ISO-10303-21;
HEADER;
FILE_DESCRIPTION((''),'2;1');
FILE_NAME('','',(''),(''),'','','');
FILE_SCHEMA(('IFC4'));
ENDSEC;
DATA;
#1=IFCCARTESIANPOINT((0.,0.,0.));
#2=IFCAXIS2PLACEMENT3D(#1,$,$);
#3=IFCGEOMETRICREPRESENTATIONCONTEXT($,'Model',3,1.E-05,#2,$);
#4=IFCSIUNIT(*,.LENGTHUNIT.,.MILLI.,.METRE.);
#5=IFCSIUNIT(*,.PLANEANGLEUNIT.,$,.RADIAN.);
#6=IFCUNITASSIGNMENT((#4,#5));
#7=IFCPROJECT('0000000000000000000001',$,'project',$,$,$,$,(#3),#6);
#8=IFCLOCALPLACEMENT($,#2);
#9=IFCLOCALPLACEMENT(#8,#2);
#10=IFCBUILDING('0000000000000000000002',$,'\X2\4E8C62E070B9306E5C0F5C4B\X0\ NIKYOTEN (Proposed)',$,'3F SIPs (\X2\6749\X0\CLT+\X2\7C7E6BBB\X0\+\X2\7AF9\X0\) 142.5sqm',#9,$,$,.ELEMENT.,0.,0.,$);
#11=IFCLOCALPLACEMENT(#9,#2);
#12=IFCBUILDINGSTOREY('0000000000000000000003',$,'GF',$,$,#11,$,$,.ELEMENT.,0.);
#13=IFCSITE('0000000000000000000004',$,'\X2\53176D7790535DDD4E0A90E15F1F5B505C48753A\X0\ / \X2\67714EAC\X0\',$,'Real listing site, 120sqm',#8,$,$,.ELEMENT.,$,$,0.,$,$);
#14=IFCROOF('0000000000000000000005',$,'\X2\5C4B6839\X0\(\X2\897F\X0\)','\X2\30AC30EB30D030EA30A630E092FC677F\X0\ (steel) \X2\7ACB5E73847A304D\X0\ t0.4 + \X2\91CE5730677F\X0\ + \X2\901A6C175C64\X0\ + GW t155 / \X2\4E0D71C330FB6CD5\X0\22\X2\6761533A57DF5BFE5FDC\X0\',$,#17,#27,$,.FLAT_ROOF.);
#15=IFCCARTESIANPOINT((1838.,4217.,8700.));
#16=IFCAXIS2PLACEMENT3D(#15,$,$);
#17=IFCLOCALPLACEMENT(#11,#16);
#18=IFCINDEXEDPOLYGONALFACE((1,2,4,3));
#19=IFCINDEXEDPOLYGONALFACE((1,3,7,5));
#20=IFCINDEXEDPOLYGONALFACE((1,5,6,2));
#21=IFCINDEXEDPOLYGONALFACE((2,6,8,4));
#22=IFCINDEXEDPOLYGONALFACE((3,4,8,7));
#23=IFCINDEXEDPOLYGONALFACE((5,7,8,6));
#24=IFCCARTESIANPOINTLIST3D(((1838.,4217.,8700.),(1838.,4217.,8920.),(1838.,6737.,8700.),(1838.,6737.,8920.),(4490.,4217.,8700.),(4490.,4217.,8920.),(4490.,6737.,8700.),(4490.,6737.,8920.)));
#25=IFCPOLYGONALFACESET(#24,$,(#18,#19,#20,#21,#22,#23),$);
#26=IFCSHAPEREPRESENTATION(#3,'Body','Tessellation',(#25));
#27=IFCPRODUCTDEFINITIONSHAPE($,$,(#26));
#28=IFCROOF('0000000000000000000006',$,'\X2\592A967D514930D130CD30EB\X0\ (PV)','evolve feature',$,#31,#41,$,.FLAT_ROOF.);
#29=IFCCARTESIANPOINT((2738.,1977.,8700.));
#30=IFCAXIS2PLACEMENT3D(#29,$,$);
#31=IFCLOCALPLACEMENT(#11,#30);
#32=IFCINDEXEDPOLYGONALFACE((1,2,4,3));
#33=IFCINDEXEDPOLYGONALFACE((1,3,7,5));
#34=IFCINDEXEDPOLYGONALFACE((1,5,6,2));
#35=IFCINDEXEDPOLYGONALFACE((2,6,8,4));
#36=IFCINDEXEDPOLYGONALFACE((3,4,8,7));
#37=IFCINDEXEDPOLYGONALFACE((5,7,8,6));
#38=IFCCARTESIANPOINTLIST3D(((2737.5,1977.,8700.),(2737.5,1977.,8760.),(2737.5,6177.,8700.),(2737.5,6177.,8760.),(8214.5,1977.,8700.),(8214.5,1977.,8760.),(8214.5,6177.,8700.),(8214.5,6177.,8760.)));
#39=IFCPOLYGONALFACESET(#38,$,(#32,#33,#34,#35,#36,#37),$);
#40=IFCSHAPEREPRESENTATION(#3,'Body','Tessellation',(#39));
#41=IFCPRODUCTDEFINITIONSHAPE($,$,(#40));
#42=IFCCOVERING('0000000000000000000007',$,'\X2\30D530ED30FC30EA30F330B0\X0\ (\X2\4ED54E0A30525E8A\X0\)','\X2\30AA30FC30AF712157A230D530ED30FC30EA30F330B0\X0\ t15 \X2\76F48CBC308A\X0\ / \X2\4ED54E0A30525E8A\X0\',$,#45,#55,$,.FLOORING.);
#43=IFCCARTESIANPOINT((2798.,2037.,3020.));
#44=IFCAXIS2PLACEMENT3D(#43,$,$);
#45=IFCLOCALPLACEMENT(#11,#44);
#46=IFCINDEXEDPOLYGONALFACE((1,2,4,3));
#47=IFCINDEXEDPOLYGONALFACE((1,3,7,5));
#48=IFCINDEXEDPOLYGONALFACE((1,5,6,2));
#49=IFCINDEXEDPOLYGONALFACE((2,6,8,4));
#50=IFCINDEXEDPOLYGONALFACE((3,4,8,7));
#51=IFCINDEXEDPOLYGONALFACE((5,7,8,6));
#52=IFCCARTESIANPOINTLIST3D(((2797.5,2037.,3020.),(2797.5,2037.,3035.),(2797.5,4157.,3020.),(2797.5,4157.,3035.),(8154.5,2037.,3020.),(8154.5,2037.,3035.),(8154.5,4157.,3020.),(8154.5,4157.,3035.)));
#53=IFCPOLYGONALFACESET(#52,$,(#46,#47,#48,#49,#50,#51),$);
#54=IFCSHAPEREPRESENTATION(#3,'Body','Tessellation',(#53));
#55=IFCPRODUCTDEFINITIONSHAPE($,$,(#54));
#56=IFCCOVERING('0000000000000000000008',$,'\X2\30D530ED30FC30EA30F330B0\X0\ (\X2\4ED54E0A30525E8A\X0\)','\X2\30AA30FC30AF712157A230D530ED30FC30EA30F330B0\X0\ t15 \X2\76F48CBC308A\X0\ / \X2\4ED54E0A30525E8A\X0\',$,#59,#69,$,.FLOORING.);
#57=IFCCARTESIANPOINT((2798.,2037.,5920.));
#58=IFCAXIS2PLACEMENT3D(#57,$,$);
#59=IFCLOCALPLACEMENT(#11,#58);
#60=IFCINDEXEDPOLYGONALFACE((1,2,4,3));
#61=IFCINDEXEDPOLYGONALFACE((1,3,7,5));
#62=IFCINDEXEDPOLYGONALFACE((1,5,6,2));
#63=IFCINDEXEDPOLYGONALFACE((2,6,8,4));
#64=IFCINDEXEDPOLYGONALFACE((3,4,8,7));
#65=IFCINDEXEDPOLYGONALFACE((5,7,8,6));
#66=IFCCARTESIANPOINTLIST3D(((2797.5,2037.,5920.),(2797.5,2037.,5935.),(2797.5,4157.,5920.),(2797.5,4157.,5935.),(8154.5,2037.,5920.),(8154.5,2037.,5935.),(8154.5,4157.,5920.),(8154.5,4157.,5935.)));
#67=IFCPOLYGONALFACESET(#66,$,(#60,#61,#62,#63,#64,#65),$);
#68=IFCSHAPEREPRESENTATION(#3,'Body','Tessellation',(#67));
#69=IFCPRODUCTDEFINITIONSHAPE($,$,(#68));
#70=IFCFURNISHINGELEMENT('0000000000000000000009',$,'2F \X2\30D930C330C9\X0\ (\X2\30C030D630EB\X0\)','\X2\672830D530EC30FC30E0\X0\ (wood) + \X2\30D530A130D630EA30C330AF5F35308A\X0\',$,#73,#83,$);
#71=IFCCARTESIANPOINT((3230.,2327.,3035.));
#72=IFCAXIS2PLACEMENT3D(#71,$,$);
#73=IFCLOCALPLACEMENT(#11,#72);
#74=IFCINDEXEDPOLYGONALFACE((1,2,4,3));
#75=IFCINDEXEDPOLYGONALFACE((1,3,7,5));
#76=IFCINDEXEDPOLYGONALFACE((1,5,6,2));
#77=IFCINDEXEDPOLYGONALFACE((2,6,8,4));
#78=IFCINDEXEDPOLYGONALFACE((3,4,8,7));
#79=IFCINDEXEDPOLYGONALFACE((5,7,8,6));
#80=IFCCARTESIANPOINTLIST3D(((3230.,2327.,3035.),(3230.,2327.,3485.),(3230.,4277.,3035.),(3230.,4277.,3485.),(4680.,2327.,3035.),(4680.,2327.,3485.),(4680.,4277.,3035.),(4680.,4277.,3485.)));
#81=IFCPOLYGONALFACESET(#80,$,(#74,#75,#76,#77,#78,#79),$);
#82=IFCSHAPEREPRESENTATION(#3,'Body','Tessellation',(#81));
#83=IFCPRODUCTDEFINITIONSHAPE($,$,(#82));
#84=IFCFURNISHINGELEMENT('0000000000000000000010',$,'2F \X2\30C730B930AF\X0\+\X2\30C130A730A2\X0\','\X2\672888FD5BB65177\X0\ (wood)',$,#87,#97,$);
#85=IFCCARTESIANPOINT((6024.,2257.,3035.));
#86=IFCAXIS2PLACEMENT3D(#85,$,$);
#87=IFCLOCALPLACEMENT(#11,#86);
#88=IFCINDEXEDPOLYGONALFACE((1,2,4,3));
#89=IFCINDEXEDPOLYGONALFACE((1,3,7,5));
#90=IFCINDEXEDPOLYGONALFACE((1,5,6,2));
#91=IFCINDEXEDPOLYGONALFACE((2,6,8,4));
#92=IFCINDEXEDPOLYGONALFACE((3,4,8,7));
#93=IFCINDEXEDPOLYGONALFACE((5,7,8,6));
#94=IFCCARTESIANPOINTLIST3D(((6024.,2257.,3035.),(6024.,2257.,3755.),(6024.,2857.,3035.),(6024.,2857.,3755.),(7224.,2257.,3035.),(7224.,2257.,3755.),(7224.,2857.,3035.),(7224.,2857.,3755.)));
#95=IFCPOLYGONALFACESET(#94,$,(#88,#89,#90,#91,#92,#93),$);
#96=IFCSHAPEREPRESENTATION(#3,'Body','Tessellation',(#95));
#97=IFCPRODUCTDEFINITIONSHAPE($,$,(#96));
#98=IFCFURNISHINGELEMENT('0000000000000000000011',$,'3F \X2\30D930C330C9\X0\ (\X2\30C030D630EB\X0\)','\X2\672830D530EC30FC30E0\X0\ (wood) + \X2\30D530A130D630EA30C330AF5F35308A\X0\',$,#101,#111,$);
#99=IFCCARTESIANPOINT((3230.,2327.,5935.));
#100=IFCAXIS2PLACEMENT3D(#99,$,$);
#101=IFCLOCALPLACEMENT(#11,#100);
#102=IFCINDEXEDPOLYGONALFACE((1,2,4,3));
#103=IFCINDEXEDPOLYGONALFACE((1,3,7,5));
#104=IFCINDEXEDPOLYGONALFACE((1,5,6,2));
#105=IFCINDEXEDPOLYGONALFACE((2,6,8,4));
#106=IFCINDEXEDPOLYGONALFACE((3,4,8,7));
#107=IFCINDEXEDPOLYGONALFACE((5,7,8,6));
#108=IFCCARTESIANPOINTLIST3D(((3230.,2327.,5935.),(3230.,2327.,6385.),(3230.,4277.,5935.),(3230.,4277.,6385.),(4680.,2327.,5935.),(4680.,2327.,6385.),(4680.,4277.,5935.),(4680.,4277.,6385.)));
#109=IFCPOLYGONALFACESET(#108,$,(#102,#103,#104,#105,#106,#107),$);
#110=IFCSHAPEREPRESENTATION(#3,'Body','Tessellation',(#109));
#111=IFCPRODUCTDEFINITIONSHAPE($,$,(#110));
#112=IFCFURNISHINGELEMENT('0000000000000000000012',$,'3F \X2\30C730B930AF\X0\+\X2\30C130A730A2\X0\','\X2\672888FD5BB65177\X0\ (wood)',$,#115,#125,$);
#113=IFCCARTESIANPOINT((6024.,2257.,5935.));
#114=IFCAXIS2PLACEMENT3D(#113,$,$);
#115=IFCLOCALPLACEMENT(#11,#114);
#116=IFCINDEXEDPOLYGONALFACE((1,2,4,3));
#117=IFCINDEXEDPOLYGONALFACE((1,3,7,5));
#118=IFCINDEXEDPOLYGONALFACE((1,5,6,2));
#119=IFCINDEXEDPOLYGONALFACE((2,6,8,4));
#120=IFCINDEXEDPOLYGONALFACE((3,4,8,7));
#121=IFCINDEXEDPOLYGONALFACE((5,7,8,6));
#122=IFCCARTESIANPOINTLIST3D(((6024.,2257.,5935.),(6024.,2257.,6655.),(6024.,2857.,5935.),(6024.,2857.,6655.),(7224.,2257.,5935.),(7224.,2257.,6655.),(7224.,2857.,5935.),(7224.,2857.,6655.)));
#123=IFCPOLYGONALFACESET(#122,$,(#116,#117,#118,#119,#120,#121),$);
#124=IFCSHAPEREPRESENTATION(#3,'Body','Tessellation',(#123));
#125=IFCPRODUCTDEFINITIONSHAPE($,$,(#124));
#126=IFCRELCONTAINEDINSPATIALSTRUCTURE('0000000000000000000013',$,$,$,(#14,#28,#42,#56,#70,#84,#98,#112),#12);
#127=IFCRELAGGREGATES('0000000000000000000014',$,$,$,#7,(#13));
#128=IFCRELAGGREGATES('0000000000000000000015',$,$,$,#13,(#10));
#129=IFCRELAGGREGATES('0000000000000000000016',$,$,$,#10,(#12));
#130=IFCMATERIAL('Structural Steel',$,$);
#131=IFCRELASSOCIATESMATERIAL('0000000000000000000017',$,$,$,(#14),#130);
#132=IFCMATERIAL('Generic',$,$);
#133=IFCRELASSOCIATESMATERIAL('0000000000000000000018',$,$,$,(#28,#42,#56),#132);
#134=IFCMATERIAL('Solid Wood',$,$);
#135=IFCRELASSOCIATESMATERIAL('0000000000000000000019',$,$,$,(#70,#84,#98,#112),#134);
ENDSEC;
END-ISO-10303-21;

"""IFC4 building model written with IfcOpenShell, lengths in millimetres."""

from ifc_helpers import new_model, si_unit, frame, frame_2d, origin, place, context, project, spatial, rectangle, extrude, material, element, save


model = new_model("IFC4")

# Units and contexts
model_context = context("Model", 3, precision=1e-05, world=origin())
ifc_project = project(units=[si_unit("LENGTHUNIT", "METRE", prefix="MILLI"), si_unit("PLANEANGLEUNIT", "RADIAN")], contexts=[model_context])

# Site, building, storey
site_placement = place(None, origin())
site = spatial("IfcSite", under=ifc_project, at=site_placement, Name="北海道川上郡弟子屈町 / 東京", ObjectType="Real listing site, 120sqm", CompositionType="ELEMENT", RefElevation=0.0)
building_placement = place(site_placement, origin())
building = spatial("IfcBuilding", under=site, at=building_placement, Name="二拠点の小屋 NIKYOTEN (Proposed)", ObjectType="3F SIPs (杉CLT+籾殻+竹) 142.5sqm", CompositionType="ELEMENT", ElevationOfRefHeight=0.0, ElevationOfTerrain=0.0)
storey_placement = place(building_placement, origin())
storey = spatial("IfcBuildingStorey", under=building, at=storey_placement, Name="GF", CompositionType="ELEMENT", Elevation=0.0)

# Shared definitions
ifc_material_1 = material(Name="Solid Wood")

# Roofs
ifc_material_2 = material(Name="Structural Steel")
roof_1_placement = place(storey_placement, frame((1838.0, 4217.0, 8700.0)))
element("IfcRoof", 1, at=roof_1_placement, inside=storey, material=ifc_material_2, Name="屋根(西)", Description="ガルバリウム鋼板 (steel) 立平葺き t0.4 + 野地板 + 通気層 + GW t155 / 不燃・法22条区域対応", PredefinedType="FLAT_ROOF", context=model_context, shape_type="SweptSolid", body=[
    extrude(rectangle(XDim=2652.0, YDim=2520.0, at=frame_2d((1326.0, 1260.0))), frame((1838.0, 4217.0, 8700.0)), (0.0, 0.0, 1.0), 220.0),
])
ifc_material_3 = material(Name="Generic")
roof_2_placement = place(storey_placement, frame((2738.0, 1977.0, 8700.0)))
element("IfcRoof", 2, at=roof_2_placement, inside=storey, material=ifc_material_3, Name="太陽光パネル (PV)", Description="evolve feature", PredefinedType="FLAT_ROOF", context=model_context, shape_type="SweptSolid", body=[
    extrude(rectangle(XDim=5477.0, YDim=4200.0, at=frame_2d((2738.0, 2100.0))), frame((2738.0, 1977.0, 8700.0)), (0.0, 0.0, 1.0), 60.0),
])

# Coverings
covering_1_placement = place(storey_placement, frame((2798.0, 2037.0, 3020.0)))
element("IfcCovering", 3, at=covering_1_placement, inside=storey, material=ifc_material_3, Name="フローリング (仕上げ床)", Description="オーク無垢フローリング t15 直貼り / 仕上げ床", PredefinedType="FLOORING", context=model_context, shape_type="SweptSolid", body=[
    extrude(rectangle(XDim=5357.0, YDim=2120.0, at=frame_2d((2678.0, 1060.0))), frame((2798.0, 2037.0, 3020.0)), (0.0, 0.0, 1.0), 15.0),
])
covering_2_placement = place(storey_placement, frame((2798.0, 2037.0, 5920.0)))
element("IfcCovering", 4, at=covering_2_placement, inside=storey, material=ifc_material_3, Name="フローリング (仕上げ床)", Description="オーク無垢フローリング t15 直貼り / 仕上げ床", PredefinedType="FLOORING", context=model_context, shape_type="SweptSolid", body=[
    extrude(rectangle(XDim=5357.0, YDim=2120.0, at=frame_2d((2678.0, 1060.0))), frame((2798.0, 2037.0, 5920.0)), (0.0, 0.0, 1.0), 15.0),
])

# Furnishing elements
furnishing_1_placement = place(storey_placement, frame((3230.0, 2327.0, 3035.0)))
element("IfcFurnishingElement", 5, at=furnishing_1_placement, inside=storey, material=ifc_material_1, Name="2F ベッド (ダブル)", Description="木フレーム (wood) + ファブリック張り", context=model_context, shape_type="SweptSolid", body=[
    extrude(rectangle(XDim=1450.0, YDim=1950.0, at=frame_2d((725.0, 975.0))), frame((3230.0, 2327.0, 3035.0)), (0.0, 0.0, 1.0), 450.0),
])
furnishing_2_placement = place(storey_placement, frame((6024.0, 2257.0, 3035.0)))
element("IfcFurnishingElement", 6, at=furnishing_2_placement, inside=storey, material=ifc_material_1, Name="2F デスク+チェア", Description="木製家具 (wood)", context=model_context, shape_type="SweptSolid", body=[
    extrude(rectangle(XDim=1200.0, YDim=600.0, at=frame_2d((600.0, 300.0))), frame((6024.0, 2257.0, 3035.0)), (0.0, 0.0, 1.0), 720.0),
])
furnishing_3_placement = place(storey_placement, frame((3230.0, 2327.0, 5935.0)))
element("IfcFurnishingElement", 7, at=furnishing_3_placement, inside=storey, material=ifc_material_1, Name="3F ベッド (ダブル)", Description="木フレーム (wood) + ファブリック張り", context=model_context, shape_type="SweptSolid", body=[
    extrude(rectangle(XDim=1450.0, YDim=1950.0, at=frame_2d((725.0, 975.0))), frame((3230.0, 2327.0, 5935.0)), (0.0, 0.0, 1.0), 450.0),
])
furnishing_4_placement = place(storey_placement, frame((6024.0, 2257.0, 5935.0)))
element("IfcFurnishingElement", 8, at=furnishing_4_placement, inside=storey, material=ifc_material_1, Name="3F デスク+チェア", Description="木製家具 (wood)", context=model_context, shape_type="SweptSolid", body=[
    extrude(rectangle(XDim=1200.0, YDim=600.0, at=frame_2d((600.0, 300.0))), frame((6024.0, 2257.0, 5935.0)), (0.0, 0.0, 1.0), 720.0),
])

save(model, "model.ifc")
